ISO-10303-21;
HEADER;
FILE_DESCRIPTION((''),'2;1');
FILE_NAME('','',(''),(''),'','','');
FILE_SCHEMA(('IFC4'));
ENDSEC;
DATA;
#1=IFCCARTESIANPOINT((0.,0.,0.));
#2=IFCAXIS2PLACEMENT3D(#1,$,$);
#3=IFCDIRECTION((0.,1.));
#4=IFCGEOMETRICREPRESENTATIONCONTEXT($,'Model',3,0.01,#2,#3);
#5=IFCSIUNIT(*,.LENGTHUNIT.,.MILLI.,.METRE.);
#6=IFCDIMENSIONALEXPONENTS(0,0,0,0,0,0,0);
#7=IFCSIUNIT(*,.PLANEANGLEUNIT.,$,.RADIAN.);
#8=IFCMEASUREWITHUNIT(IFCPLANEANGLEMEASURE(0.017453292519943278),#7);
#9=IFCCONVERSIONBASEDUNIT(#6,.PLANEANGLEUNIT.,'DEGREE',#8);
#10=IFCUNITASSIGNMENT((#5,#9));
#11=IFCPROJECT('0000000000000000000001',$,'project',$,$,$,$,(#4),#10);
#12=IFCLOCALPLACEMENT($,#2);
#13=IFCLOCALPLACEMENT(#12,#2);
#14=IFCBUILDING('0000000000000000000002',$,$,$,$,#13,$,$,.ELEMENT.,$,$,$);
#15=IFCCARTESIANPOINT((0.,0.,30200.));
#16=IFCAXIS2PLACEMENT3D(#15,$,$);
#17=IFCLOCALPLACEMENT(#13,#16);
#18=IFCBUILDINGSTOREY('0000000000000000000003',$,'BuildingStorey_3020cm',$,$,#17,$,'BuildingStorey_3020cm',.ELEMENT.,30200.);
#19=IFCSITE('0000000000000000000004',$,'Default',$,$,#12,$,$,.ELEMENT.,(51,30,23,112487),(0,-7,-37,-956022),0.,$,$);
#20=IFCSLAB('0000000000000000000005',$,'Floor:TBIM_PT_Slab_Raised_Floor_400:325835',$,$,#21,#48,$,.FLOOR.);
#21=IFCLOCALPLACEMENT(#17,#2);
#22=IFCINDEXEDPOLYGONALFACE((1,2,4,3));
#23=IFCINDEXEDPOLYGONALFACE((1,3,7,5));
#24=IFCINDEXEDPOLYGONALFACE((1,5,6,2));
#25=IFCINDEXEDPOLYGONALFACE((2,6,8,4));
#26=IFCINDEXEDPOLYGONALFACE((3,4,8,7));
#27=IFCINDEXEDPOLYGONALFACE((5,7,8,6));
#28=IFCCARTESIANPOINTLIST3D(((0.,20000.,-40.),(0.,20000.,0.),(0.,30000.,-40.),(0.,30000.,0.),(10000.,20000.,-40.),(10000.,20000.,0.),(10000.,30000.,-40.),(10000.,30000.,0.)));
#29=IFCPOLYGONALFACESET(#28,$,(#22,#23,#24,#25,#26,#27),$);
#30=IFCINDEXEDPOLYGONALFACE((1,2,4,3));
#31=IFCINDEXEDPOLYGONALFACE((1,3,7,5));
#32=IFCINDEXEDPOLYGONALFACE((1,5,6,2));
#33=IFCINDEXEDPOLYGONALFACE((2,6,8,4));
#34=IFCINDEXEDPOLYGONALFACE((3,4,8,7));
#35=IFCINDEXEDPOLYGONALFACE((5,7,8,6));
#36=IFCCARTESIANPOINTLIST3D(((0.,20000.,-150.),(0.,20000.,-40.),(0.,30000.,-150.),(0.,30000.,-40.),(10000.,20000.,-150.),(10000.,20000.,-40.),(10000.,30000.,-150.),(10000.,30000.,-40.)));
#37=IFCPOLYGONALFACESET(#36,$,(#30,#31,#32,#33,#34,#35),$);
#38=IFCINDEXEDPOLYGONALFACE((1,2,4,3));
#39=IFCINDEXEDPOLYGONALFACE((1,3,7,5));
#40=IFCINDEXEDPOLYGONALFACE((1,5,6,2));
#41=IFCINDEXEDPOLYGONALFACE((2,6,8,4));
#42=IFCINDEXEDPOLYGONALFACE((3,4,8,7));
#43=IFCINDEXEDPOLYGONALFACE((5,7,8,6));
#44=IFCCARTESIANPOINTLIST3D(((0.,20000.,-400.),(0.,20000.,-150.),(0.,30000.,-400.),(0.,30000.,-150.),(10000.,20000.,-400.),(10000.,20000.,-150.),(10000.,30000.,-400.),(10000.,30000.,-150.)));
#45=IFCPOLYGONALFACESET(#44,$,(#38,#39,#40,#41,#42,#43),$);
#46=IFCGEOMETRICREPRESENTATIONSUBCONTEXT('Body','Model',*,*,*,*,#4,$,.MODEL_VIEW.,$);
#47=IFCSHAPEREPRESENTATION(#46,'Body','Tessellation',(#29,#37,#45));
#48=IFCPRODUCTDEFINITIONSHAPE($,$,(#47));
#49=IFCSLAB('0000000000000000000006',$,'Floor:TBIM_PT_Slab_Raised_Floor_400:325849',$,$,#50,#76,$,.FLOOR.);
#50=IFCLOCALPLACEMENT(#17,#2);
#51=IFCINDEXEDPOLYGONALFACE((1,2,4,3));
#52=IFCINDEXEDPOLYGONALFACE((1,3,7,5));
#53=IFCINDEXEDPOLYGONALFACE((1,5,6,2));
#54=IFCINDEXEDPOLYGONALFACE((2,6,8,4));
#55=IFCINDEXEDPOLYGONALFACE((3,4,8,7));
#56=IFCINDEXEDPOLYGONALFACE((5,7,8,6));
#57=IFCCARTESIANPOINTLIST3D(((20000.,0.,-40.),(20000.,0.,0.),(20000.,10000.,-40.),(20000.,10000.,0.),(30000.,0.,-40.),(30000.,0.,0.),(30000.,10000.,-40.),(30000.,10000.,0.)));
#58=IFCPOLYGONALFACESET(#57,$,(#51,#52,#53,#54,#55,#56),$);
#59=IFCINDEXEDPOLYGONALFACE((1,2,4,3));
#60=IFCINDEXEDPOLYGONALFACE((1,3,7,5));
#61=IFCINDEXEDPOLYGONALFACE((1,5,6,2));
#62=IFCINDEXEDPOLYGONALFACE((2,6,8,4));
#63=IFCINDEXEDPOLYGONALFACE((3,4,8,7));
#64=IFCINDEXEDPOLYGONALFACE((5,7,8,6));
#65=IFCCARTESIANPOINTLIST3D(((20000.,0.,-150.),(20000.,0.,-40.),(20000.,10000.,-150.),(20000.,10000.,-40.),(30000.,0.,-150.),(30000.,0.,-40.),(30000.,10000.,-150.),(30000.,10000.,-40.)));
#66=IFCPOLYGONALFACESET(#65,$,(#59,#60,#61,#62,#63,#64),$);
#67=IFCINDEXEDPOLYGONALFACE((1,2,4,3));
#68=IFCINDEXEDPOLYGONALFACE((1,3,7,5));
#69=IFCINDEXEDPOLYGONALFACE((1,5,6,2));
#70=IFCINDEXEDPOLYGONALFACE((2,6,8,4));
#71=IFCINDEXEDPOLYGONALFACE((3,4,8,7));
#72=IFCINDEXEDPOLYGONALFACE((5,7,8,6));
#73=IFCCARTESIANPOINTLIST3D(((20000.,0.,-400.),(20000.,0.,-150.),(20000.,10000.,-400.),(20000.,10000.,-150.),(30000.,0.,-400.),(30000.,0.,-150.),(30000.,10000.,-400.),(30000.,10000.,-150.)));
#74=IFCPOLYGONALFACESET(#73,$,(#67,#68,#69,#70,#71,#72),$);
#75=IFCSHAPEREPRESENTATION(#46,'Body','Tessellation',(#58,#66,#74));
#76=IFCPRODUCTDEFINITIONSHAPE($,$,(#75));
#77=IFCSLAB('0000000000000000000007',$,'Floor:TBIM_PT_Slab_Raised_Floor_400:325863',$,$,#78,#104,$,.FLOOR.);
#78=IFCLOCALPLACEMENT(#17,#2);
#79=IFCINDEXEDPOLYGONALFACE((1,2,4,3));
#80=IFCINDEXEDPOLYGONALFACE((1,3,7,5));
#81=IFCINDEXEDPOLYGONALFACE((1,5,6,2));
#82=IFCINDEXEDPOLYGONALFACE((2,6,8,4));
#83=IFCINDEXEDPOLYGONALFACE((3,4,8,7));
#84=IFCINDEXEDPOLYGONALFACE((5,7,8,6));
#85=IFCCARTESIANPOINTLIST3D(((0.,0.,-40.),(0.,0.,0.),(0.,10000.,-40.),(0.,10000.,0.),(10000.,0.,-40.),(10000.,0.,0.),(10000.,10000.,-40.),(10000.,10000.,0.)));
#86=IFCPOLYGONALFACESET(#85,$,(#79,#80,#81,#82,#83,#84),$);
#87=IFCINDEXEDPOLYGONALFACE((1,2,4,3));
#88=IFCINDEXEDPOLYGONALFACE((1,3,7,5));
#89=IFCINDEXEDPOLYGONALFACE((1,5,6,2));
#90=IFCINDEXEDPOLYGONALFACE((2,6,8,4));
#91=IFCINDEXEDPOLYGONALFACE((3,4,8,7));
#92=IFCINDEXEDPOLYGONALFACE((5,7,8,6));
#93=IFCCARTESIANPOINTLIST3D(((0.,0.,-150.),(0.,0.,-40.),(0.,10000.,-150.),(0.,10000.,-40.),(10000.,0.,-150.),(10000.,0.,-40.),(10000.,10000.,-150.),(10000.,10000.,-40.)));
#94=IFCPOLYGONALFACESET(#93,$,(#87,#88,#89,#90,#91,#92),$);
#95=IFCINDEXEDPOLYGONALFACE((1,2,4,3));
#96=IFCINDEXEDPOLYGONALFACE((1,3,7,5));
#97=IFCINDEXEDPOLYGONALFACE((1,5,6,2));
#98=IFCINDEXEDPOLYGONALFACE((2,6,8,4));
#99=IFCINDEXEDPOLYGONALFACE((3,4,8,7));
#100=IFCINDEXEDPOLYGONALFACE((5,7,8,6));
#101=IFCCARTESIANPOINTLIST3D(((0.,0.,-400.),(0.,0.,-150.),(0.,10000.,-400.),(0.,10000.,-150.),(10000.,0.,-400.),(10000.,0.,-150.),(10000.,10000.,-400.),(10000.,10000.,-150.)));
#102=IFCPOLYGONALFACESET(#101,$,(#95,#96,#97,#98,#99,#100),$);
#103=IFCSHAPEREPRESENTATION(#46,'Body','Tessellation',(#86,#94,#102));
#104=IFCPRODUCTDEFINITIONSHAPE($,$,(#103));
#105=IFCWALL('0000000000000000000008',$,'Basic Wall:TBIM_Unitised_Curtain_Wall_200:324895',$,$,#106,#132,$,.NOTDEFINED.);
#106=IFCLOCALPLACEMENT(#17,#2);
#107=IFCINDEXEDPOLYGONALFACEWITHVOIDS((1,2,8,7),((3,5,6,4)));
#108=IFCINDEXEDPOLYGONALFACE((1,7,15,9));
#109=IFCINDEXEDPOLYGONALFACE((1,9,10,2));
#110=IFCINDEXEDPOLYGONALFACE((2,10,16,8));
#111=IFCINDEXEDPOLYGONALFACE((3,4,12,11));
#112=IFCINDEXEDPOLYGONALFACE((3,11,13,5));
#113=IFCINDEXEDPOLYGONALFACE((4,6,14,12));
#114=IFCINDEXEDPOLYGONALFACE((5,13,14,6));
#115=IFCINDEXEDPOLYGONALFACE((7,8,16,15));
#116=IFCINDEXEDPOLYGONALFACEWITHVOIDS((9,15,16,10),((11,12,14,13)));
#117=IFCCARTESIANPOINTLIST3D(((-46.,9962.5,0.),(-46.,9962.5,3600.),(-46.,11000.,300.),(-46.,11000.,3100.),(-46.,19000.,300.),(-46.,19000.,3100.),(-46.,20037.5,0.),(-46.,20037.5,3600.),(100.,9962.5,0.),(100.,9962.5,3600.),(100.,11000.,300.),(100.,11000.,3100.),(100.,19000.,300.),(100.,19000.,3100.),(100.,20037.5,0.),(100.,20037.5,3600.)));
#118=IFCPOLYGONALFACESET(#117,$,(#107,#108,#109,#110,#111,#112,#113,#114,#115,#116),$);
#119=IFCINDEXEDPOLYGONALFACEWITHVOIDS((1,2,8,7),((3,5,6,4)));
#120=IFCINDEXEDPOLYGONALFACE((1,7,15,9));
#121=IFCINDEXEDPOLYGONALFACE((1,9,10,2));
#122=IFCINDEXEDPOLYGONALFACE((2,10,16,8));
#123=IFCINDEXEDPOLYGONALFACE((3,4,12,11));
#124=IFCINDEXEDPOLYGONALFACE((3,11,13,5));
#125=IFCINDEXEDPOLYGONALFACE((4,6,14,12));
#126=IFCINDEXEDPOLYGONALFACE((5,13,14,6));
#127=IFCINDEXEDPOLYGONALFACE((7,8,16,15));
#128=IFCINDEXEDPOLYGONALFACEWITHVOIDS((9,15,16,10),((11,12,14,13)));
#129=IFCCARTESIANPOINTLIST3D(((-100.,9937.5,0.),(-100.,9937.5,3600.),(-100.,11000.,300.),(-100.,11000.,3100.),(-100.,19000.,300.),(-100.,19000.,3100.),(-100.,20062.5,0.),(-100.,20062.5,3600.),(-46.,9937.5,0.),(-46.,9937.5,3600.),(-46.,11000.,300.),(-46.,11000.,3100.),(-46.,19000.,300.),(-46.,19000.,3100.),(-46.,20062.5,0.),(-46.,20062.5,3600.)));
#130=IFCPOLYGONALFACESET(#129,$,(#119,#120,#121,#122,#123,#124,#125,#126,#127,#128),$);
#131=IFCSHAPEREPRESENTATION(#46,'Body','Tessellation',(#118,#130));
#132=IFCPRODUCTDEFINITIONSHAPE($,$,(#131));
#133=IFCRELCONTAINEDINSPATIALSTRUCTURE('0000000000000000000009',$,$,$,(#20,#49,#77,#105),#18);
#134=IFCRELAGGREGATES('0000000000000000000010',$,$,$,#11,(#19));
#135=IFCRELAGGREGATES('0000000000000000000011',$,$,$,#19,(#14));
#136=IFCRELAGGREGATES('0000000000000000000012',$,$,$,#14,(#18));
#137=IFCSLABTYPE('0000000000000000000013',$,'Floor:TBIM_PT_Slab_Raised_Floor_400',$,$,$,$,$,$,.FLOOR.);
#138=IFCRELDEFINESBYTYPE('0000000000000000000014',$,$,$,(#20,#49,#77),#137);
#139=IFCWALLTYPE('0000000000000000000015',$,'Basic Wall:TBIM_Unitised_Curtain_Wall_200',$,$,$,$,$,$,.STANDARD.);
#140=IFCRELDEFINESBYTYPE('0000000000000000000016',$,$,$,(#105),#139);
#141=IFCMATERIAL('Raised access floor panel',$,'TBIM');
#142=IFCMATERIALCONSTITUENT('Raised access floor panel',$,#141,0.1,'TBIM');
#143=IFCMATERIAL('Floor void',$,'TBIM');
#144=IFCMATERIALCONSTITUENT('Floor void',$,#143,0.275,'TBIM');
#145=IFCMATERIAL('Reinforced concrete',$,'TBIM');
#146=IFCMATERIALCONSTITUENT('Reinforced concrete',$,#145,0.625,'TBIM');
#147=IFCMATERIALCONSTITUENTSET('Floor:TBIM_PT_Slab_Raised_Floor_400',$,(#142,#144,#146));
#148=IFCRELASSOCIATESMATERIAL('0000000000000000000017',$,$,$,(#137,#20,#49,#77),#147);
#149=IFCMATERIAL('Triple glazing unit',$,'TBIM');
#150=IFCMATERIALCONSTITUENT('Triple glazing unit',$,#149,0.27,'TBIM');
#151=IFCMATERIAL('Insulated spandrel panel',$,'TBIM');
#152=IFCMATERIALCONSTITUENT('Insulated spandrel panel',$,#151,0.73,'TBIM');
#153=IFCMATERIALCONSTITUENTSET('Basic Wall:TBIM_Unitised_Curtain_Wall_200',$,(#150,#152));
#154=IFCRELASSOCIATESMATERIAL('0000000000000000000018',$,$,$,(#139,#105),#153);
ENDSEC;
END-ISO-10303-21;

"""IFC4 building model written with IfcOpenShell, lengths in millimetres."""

from ifc_helpers import new_model, entity, si_unit, converted_unit, direction, frame, origin, place, context, subcontext, project, spatial, indexed_curve, outline, extrude, material, constituent, constituent_set, type_object, element, save


model = new_model("IFC4")

# Units and contexts
model_context = context("Model", 3, precision=0.01, world=origin(), true_north=direction((0.0, 1.0)))
body_context = subcontext(model_context, "Body", "Model", "MODEL_VIEW")
ifc_project = project(units=[si_unit("LENGTHUNIT", "METRE", prefix="MILLI"), converted_unit("PLANEANGLEUNIT", "DEGREE", entity("IfcPlaneAngleMeasure", 0.017453292519943278), si_unit("PLANEANGLEUNIT", "RADIAN"), dimensions=[0, 0, 0, 0, 0, 0, 0])], contexts=[model_context])

# Site, building, storey
site_placement = place(None, origin())
site = spatial("IfcSite", under=ifc_project, at=site_placement, Name="Default", CompositionType="ELEMENT", RefLatitude=(51, 30, 23, 112487), RefLongitude=(0, -7, -37, -956022), RefElevation=0.0)
building_placement = place(site_placement, origin())
building = spatial("IfcBuilding", under=site, at=building_placement, CompositionType="ELEMENT")
storey_placement = place(building_placement, frame((0.0, 0.0, 30200.0)))
storey = spatial("IfcBuildingStorey", under=building, at=storey_placement, Name="BuildingStorey_3020cm", LongName="BuildingStorey_3020cm", CompositionType="ELEMENT", Elevation=30200.0)

# Slabs
ifc_material_1 = material(Name="Raised access floor panel", Category="TBIM")
ifc_constituent_1 = constituent(ifc_material_1, Name="Raised access floor panel", Category="TBIM", fraction=0.1)
ifc_material_2 = material(Name="Floor void", Category="TBIM")
ifc_constituent_2 = constituent(ifc_material_2, Name="Floor void", Category="TBIM", fraction=0.275)
ifc_material_3 = material(Name="Reinforced concrete", Category="TBIM")
ifc_constituent_3 = constituent(ifc_material_3, Name="Reinforced concrete", Category="TBIM", fraction=0.625)
ifc_constituent_set_1 = constituent_set(constituents=[ifc_constituent_1, ifc_constituent_2, ifc_constituent_3], Name="Floor:TBIM_PT_Slab_Raised_Floor_400")
slab_type = type_object("IfcSlabType", Name="Floor:TBIM_PT_Slab_Raised_Floor_400", PredefinedType="FLOOR", material=ifc_constituent_set_1)
slab_1_placement = place(storey_placement, origin())
element("IfcSlab", 1, at=slab_1_placement, inside=storey, type_object=slab_type, material=ifc_constituent_set_1, Name="Floor:TBIM_PT_Slab_Raised_Floor_400:325835", PredefinedType="FLOOR", context=body_context, shape_type="SweptSolid", body=[
    extrude(outline(indexed_curve([(-5000.0, -5000.0), (5000.0, -5000.0), (5000.0, 5000.0), (-5000.0, 5000.0), (-5000.0, -5000.0)], self_intersect=False)), frame((5000.0, 25000.0, -40.0), z_axis=(0.0, 0.0, 1.0), x_axis=(-1.0, 0.0, 0.0)), (0.0, 0.0, 1.0), 40.0),
    extrude(outline(indexed_curve([(-5000.0, -5000.0), (5000.0, -5000.0), (5000.0, 5000.0), (-5000.0, 5000.0), (-5000.0, -5000.0)], self_intersect=False)), frame((5000.0, 25000.0, -150.0), z_axis=(0.0, 0.0, 1.0), x_axis=(-1.0, 0.0, 0.0)), (0.0, 0.0, 1.0), 110.0),
    extrude(outline(indexed_curve([(-5000.0, -5000.0), (5000.0, -5000.0), (5000.0, 5000.0), (-5000.0, 5000.0), (-5000.0, -5000.0)], self_intersect=False)), frame((5000.0, 25000.0, -400.0), z_axis=(0.0, 0.0, 1.0), x_axis=(-1.0, 0.0, 0.0)), (0.0, 0.0, 1.0), 250.0),
])
slab_2_placement = place(storey_placement, origin())
element("IfcSlab", 2, at=slab_2_placement, inside=storey, type_object=slab_type, material=ifc_constituent_set_1, Name="Floor:TBIM_PT_Slab_Raised_Floor_400:325849", PredefinedType="FLOOR", context=body_context, shape_type="SweptSolid", body=[
    extrude(outline(indexed_curve([(-5000.0, -5000.0), (5000.0, -5000.0), (5000.0, 5000.0), (-5000.0, 5000.0), (-5000.0, -5000.0)], self_intersect=False)), frame((25000.0, 5000.0, -40.0), z_axis=(0.0, 0.0, 1.0), x_axis=(-1.0, 0.0, 0.0)), (0.0, 0.0, 1.0), 40.0),
    extrude(outline(indexed_curve([(-5000.0, -5000.0), (5000.0, -5000.0), (5000.0, 5000.0), (-5000.0, 5000.0), (-5000.0, -5000.0)], self_intersect=False)), frame((25000.0, 5000.0, -150.0), z_axis=(0.0, 0.0, 1.0), x_axis=(-1.0, 0.0, 0.0)), (0.0, 0.0, 1.0), 110.0),
    extrude(outline(indexed_curve([(-5000.0, -5000.0), (5000.0, -5000.0), (5000.0, 5000.0), (-5000.0, 5000.0), (-5000.0, -5000.0)], self_intersect=False)), frame((25000.0, 5000.0, -400.0), z_axis=(0.0, 0.0, 1.0), x_axis=(-1.0, 0.0, 0.0)), (0.0, 0.0, 1.0), 250.0),
])
slab_3_placement = place(storey_placement, origin())
element("IfcSlab", 3, at=slab_3_placement, inside=storey, type_object=slab_type, material=ifc_constituent_set_1, Name="Floor:TBIM_PT_Slab_Raised_Floor_400:325863", PredefinedType="FLOOR", context=body_context, shape_type="SweptSolid", body=[
    extrude(outline(indexed_curve([(-5000.0, -5000.0), (5000.0, -5000.0), (5000.0, 5000.0), (-5000.0, 5000.0), (-5000.0, -5000.0)], self_intersect=False)), frame((5000.0, 5000.0, -40.0), z_axis=(0.0, 0.0, 1.0), x_axis=(-1.0, 0.0, 0.0)), (0.0, 0.0, 1.0), 40.0),
    extrude(outline(indexed_curve([(-5000.0, -5000.0), (5000.0, -5000.0), (5000.0, 5000.0), (-5000.0, 5000.0), (-5000.0, -5000.0)], self_intersect=False)), frame((5000.0, 5000.0, -150.0), z_axis=(0.0, 0.0, 1.0), x_axis=(-1.0, 0.0, 0.0)), (0.0, 0.0, 1.0), 110.0),
    extrude(outline(indexed_curve([(-5000.0, -5000.0), (5000.0, -5000.0), (5000.0, 5000.0), (-5000.0, 5000.0), (-5000.0, -5000.0)], self_intersect=False)), frame((5000.0, 5000.0, -400.0), z_axis=(0.0, 0.0, 1.0), x_axis=(-1.0, 0.0, 0.0)), (0.0, 0.0, 1.0), 250.0),
])

# Wall, opening
ifc_material_4 = material(Name="Triple glazing unit", Category="TBIM")
ifc_constituent_4 = constituent(ifc_material_4, Name="Triple glazing unit", Category="TBIM", fraction=0.27)
ifc_material_5 = material(Name="Insulated spandrel panel", Category="TBIM")
ifc_constituent_5 = constituent(ifc_material_5, Name="Insulated spandrel panel", Category="TBIM", fraction=0.73)
ifc_constituent_set_2 = constituent_set(constituents=[ifc_constituent_4, ifc_constituent_5], Name="Basic Wall:TBIM_Unitised_Curtain_Wall_200")
wall_type = type_object("IfcWallType", Name="Basic Wall:TBIM_Unitised_Curtain_Wall_200", PredefinedType="STANDARD", material=ifc_constituent_set_2)
wall_1_placement = place(storey_placement, frame((0.0, 9937.5, 0.0), z_axis=(0.0, 0.0, 1.0), x_axis=(0.0, 1.0, 0.0)))
wall_1 = element("IfcWall", 4, at=wall_1_placement, inside=storey, type_object=wall_type, material=ifc_constituent_set_2, Name="Basic Wall:TBIM_Unitised_Curtain_Wall_200:324895", PredefinedType="NOTDEFINED", context=body_context, shape_type="SweptSolid", body=[
    extrude(outline(indexed_curve([(-1800.0, -5037.5), (1800.0, -5037.5), (1800.0, 5037.5), (-1800.0, 5037.5), (-1800.0, -5037.5)], self_intersect=False), holes=[indexed_curve([(1300.0, 4000.0), (1300.0, -4000.0), (-1500.0, -4000.0), (-1500.0, 4000.0), (1300.0, 4000.0)], self_intersect=False)]), frame((5062.5, 46.0, 1800.0), z_axis=(0.0, -1.0, 0.0), x_axis=(0.0, 0.0, 1.0)), (0.0, 0.0, 1.0), 146.0),
    extrude(outline(indexed_curve([(-5062.5, -1800.0), (5062.5, -1800.0), (5062.5, 1800.0), (-5062.5, 1800.0), (-5062.5, -1800.0)], self_intersect=False), holes=[indexed_curve([(-4000.0, 1300.0), (4000.0, 1300.0), (4000.0, -1500.0), (-4000.0, -1500.0), (-4000.0, 1300.0)], self_intersect=False)]), frame((5062.5, 100.0, 1800.0), z_axis=(0.0, -1.0, 0.0), x_axis=(1.0, 0.0, 0.0)), (0.0, 0.0, 1.0), 54.0),
])
opening_1_placement = place(wall_1_placement, frame((1062.5, -100.0, 300.0)))
element("IfcOpeningElement", 5, at=opening_1_placement, cuts=wall_1, PredefinedType="OPENING", context=body_context, shape_type="SweptSolid", body=[
    extrude(outline(indexed_curve([(2800.0, 0.0), (2800.0, 8000.0), (0.0, 8000.0), (0.0, 0.0), (2800.0, 0.0)], self_intersect=False)), frame((0.0, 0.0, 0.0), z_axis=(0.0, 1.0, 0.0), x_axis=(0.0, 0.0, 1.0)), (0.0, 0.0, 1.0), 200.0),
])

save(model, "model.ifc")
